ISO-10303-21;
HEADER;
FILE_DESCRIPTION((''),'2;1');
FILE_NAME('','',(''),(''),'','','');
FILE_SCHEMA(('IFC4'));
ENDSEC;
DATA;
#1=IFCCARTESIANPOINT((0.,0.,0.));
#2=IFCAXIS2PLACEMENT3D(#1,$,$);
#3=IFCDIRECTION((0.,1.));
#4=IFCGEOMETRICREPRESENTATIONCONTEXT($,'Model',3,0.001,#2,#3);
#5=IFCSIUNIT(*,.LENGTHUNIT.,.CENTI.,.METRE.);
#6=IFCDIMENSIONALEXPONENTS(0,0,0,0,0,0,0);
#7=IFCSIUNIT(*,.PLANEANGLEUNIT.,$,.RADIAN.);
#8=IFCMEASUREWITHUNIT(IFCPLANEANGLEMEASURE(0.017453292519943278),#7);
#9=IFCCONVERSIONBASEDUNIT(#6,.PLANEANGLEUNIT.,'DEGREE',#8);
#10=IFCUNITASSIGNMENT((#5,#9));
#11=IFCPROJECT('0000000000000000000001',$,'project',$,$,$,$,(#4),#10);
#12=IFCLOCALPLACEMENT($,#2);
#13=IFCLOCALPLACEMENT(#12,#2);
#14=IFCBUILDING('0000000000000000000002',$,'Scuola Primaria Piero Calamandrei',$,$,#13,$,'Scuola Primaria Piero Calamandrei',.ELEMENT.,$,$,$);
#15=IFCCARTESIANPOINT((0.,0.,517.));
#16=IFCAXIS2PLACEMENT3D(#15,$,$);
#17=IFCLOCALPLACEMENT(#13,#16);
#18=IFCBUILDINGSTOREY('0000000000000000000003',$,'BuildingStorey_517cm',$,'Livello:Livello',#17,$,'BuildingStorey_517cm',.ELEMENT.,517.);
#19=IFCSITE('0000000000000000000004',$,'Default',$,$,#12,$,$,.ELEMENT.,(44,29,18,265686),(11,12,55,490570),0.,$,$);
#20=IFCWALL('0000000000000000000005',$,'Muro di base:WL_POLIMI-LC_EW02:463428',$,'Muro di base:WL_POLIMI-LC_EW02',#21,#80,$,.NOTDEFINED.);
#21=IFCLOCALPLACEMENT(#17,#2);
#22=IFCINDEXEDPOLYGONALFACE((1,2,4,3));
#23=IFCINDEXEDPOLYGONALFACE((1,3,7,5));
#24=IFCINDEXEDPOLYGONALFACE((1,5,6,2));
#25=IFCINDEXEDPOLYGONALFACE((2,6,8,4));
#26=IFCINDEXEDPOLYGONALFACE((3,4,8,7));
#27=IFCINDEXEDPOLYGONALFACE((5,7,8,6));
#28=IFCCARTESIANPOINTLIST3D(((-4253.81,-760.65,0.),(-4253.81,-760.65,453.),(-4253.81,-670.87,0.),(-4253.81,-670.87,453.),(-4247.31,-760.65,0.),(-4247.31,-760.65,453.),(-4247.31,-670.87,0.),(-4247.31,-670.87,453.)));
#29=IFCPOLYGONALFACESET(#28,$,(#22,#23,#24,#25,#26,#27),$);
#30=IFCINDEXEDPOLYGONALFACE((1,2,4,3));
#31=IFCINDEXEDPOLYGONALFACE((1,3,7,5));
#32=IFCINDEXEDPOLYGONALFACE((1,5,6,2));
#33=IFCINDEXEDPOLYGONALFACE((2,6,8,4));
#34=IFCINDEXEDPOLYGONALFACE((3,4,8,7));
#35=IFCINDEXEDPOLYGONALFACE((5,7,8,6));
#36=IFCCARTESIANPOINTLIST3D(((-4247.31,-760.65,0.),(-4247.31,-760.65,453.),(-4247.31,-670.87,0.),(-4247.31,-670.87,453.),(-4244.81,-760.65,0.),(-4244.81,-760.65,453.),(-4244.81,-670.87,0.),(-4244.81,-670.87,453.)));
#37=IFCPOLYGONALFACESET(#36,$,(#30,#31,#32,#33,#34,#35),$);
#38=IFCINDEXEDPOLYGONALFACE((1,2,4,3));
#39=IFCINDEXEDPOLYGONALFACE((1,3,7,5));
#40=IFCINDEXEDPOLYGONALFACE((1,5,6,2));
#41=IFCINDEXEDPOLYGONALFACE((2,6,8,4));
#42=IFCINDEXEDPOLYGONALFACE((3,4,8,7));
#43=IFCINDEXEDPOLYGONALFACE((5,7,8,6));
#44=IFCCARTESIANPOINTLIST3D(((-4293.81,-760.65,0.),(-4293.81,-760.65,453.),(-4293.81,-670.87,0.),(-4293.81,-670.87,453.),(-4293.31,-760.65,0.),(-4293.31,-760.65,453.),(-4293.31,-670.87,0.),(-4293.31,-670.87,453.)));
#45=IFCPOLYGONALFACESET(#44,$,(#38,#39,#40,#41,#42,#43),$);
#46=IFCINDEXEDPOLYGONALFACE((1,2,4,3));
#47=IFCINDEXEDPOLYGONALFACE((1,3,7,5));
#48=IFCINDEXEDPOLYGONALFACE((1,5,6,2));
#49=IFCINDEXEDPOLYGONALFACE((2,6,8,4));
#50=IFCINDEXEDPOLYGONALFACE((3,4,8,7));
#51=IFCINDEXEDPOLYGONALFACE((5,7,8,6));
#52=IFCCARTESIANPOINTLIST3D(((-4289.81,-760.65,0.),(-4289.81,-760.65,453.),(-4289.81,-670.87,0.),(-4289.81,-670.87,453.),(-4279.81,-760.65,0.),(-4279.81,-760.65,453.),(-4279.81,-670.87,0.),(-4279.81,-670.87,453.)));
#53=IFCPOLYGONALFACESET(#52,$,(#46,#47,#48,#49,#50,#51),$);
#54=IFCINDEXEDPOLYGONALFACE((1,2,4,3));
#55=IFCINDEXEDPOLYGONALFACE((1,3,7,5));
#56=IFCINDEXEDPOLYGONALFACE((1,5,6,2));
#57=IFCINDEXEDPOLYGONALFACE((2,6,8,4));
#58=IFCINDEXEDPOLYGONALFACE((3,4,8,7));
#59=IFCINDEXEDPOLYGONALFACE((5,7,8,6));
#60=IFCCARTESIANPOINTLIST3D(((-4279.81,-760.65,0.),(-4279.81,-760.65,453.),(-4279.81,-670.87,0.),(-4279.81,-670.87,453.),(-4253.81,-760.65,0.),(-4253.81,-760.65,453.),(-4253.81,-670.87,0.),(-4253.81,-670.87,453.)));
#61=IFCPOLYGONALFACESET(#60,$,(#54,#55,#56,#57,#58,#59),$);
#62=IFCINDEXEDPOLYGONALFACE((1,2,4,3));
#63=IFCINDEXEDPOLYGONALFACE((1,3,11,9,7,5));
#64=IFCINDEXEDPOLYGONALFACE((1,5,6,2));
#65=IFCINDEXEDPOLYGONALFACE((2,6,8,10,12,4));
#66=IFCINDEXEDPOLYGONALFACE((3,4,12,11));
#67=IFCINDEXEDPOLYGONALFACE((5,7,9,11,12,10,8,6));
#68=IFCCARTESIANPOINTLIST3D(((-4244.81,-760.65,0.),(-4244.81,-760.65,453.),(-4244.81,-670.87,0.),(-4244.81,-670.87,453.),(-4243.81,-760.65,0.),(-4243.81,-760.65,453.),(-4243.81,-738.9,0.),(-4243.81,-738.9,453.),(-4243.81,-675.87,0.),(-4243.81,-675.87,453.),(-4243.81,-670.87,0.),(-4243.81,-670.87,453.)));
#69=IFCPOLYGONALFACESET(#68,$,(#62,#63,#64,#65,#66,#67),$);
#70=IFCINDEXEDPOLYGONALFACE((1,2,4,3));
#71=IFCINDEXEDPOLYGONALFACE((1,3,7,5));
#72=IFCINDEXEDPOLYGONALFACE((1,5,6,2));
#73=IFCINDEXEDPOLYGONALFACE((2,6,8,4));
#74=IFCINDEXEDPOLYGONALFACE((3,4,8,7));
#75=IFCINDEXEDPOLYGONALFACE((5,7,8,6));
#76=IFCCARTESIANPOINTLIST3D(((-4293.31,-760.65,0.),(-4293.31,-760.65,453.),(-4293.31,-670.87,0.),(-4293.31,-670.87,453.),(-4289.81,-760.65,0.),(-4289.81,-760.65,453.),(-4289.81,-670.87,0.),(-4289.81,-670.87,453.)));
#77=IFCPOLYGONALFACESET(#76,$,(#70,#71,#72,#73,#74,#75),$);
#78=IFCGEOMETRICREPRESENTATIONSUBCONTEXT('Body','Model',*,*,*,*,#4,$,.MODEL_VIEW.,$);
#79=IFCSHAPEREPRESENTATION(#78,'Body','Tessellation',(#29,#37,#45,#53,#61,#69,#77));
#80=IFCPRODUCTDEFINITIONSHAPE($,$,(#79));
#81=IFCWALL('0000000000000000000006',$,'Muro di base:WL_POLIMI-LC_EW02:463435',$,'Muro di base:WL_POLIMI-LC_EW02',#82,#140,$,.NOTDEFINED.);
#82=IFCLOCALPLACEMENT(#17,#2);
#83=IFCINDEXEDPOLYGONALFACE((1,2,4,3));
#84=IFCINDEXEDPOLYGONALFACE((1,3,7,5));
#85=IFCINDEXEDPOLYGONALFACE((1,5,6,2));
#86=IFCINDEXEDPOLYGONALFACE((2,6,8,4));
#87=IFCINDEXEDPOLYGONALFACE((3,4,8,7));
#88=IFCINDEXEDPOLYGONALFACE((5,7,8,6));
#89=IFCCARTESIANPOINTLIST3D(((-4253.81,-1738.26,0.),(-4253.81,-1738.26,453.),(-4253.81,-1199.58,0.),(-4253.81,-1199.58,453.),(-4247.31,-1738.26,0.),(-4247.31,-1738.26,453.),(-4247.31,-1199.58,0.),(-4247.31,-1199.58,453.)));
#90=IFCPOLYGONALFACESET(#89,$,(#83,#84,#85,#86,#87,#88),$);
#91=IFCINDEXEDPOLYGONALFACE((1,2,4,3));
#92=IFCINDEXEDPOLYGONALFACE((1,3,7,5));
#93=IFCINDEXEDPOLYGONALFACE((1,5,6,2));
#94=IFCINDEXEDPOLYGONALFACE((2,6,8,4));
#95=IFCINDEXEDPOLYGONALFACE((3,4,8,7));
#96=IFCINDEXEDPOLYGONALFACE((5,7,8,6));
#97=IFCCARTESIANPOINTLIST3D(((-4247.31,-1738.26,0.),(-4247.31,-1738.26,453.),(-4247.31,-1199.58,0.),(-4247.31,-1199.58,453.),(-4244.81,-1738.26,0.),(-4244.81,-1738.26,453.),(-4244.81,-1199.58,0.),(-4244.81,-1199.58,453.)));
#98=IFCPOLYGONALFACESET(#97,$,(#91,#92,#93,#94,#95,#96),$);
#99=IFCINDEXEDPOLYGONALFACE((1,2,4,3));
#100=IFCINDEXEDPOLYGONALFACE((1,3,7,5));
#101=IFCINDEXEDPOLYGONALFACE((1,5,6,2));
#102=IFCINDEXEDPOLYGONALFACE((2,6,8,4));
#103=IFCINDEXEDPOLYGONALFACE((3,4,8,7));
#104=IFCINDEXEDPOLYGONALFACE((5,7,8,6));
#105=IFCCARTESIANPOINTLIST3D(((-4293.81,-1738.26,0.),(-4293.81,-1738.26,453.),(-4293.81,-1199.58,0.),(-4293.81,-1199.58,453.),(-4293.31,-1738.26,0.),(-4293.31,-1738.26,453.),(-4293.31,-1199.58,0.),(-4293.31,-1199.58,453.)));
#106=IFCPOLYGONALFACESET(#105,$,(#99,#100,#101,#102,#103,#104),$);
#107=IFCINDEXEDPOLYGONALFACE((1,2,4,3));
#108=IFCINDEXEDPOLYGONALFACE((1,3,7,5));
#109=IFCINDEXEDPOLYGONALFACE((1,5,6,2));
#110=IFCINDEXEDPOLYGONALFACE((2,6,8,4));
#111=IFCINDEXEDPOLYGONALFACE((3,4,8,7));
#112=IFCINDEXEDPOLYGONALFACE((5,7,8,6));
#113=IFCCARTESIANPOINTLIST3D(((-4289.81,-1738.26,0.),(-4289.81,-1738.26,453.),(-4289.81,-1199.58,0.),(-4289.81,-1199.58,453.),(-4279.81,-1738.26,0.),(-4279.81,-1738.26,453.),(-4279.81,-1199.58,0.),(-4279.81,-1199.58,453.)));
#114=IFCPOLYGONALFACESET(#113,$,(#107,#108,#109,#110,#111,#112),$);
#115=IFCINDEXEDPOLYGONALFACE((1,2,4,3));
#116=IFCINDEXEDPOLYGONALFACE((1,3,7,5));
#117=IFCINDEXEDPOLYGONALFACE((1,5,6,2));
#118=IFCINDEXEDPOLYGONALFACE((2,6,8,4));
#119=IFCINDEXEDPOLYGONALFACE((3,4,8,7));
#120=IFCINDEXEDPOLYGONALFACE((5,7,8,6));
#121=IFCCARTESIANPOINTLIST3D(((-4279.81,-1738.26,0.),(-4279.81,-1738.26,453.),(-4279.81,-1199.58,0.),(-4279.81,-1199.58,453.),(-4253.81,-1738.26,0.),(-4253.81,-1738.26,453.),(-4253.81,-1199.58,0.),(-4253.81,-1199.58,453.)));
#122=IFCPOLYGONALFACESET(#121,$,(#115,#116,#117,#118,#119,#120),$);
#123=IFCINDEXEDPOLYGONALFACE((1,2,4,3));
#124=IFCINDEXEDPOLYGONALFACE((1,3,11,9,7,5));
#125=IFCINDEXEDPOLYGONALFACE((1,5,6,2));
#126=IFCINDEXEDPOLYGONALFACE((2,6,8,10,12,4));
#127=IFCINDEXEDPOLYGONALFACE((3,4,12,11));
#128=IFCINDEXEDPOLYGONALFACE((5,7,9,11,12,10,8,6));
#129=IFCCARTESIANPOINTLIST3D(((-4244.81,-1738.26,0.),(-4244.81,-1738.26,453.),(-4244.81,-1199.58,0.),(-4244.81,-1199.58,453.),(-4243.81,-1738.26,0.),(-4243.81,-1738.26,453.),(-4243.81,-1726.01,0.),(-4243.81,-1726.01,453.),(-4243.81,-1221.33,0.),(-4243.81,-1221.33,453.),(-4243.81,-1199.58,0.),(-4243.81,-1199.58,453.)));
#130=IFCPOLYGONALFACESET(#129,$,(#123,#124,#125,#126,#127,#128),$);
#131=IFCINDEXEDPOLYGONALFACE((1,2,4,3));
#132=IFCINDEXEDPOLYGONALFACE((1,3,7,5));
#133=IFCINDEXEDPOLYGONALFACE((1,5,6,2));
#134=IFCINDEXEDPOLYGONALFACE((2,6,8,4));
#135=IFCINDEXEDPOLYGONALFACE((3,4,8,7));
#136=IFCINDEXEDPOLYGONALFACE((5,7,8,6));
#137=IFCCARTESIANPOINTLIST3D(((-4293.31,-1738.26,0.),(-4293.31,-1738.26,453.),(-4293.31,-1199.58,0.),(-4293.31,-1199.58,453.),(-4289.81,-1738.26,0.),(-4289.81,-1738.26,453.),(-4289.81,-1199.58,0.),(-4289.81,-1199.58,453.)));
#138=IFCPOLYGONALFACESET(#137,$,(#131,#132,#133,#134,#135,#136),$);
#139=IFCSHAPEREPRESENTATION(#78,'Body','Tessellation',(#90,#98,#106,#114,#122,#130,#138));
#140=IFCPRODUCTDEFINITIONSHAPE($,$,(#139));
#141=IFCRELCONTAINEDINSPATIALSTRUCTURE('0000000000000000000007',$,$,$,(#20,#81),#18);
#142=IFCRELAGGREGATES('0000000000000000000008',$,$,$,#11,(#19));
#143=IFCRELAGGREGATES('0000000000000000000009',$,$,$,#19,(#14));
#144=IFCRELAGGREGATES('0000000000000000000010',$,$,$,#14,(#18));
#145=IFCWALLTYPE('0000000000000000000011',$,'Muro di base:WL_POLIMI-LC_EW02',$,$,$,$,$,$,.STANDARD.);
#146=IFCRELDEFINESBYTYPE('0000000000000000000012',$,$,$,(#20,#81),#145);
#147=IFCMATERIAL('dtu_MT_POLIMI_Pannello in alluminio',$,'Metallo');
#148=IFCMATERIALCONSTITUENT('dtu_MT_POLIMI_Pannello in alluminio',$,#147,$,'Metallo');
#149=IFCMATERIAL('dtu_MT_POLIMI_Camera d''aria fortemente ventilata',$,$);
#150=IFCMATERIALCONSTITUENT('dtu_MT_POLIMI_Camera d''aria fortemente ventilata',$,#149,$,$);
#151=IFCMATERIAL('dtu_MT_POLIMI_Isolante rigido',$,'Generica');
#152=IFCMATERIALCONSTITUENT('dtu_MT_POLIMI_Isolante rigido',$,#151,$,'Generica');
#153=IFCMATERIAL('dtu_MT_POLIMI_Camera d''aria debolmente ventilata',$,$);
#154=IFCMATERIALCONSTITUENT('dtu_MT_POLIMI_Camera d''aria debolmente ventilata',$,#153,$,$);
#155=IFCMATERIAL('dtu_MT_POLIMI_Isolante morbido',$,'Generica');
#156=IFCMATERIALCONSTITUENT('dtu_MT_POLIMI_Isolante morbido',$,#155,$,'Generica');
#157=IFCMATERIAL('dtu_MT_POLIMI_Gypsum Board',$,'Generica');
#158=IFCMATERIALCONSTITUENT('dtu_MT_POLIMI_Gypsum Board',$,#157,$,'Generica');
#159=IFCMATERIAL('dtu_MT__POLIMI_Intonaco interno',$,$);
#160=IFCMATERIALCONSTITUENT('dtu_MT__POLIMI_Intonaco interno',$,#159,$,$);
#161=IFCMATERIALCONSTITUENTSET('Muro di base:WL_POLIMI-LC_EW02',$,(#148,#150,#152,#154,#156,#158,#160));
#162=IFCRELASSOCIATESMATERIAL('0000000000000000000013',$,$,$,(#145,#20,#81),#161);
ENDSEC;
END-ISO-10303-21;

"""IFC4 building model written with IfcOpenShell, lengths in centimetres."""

from ifc_helpers import new_model, entity, si_unit, converted_unit, direction, frame, origin, place, context, subcontext, project, spatial, indexed_curve, outline, extrude, material, constituent, constituent_set, type_object, element, save


model = new_model("IFC4")

# Units and contexts
model_context = context("Model", 3, precision=0.001, world=origin(), true_north=direction((0.0, 1.0)))
body_context = subcontext(model_context, "Body", "Model", "MODEL_VIEW")
ifc_project = project(units=[si_unit("LENGTHUNIT", "METRE", prefix="CENTI"), converted_unit("PLANEANGLEUNIT", "DEGREE", entity("IfcPlaneAngleMeasure", 0.017453292519943278), si_unit("PLANEANGLEUNIT", "RADIAN"), dimensions=[0, 0, 0, 0, 0, 0, 0])], contexts=[model_context])

# Site, building, storey
site_placement = place(None, origin())
site = spatial("IfcSite", under=ifc_project, at=site_placement, Name="Default", CompositionType="ELEMENT", RefLatitude=(44, 29, 18, 265686), RefLongitude=(11, 12, 55, 490570), RefElevation=0.0)
building_placement = place(site_placement, origin())
building = spatial("IfcBuilding", under=site, at=building_placement, Name="Scuola Primaria Piero Calamandrei", LongName="Scuola Primaria Piero Calamandrei", CompositionType="ELEMENT")
storey_placement = place(building_placement, frame((0.0, 0.0, 517.0)))
storey = spatial("IfcBuildingStorey", under=building, at=storey_placement, Name="BuildingStorey_517cm", ObjectType="Livello:Livello", LongName="BuildingStorey_517cm", CompositionType="ELEMENT", Elevation=517.0)

# Walls
ifc_material_1 = material(Name="dtu_MT_POLIMI_Pannello in alluminio", Category="Metallo")
ifc_constituent_1 = constituent(ifc_material_1, Name="dtu_MT_POLIMI_Pannello in alluminio", Category="Metallo")
ifc_material_2 = material(Name="dtu_MT_POLIMI_Camera d'aria fortemente ventilata")
ifc_constituent_2 = constituent(ifc_material_2, Name="dtu_MT_POLIMI_Camera d'aria fortemente ventilata")
ifc_material_3 = material(Name="dtu_MT_POLIMI_Isolante rigido", Category="Generica")
ifc_constituent_3 = constituent(ifc_material_3, Name="dtu_MT_POLIMI_Isolante rigido", Category="Generica")
ifc_material_4 = material(Name="dtu_MT_POLIMI_Camera d'aria debolmente ventilata")
ifc_constituent_4 = constituent(ifc_material_4, Name="dtu_MT_POLIMI_Camera d'aria debolmente ventilata")
ifc_material_5 = material(Name="dtu_MT_POLIMI_Isolante morbido", Category="Generica")
ifc_constituent_5 = constituent(ifc_material_5, Name="dtu_MT_POLIMI_Isolante morbido", Category="Generica")
ifc_material_6 = material(Name="dtu_MT_POLIMI_Gypsum Board", Category="Generica")
ifc_constituent_6 = constituent(ifc_material_6, Name="dtu_MT_POLIMI_Gypsum Board", Category="Generica")
ifc_material_7 = material(Name="dtu_MT__POLIMI_Intonaco interno")
ifc_constituent_7 = constituent(ifc_material_7, Name="dtu_MT__POLIMI_Intonaco interno")
ifc_constituent_set_1 = constituent_set(constituents=[ifc_constituent_1, ifc_constituent_2, ifc_constituent_3, ifc_constituent_4, ifc_constituent_5, ifc_constituent_6, ifc_constituent_7], Name="Muro di base:WL_POLIMI-LC_EW02")
wall_type_1 = type_object("IfcWallType", Name="Muro di base:WL_POLIMI-LC_EW02", PredefinedType="STANDARD", material=ifc_constituent_set_1)
wall_1_placement = place(storey_placement, frame((-4268.81, -760.65, 0.0), z_axis=(0.0, 0.0, 1.0), x_axis=(0.0, 1.0, 0.0)))
element("IfcWall", 1, at=wall_1_placement, inside=storey, type_object=wall_type_1, material=ifc_constituent_set_1, Name="Muro di base:WL_POLIMI-LC_EW02:463428", ObjectType="Muro di base:WL_POLIMI-LC_EW02", PredefinedType="NOTDEFINED", context=body_context, shape_type="SweptSolid", body=[
    extrude(outline(indexed_curve([(-44.89, -3.25), (44.89, -3.25), (44.89, 3.25), (-44.89, 3.25), (-44.89, -3.25)], self_intersect=False)), frame((44.89, -18.25, 0.0)), (0.0, 0.0, 1.0), 453.0),
    extrude(outline(indexed_curve([(-44.89, -1.25), (44.89, -1.25), (44.89, 1.25), (-44.89, 1.25), (-44.89, -1.25)], self_intersect=False)), frame((44.89, -22.75, 0.0)), (0.0, 0.0, 1.0), 453.0),
    extrude(outline(indexed_curve([(-0.25, -44.89), (0.25, -44.89), (0.25, 44.89), (-0.25, 44.89), (-0.25, -44.89)], self_intersect=False)), frame((44.89, 24.75, 0.0), z_axis=(0.0, 0.0, 1.0), x_axis=(0.0, -1.0, 0.0)), (0.0, 0.0, 1.0), 453.0),
    extrude(outline(indexed_curve([(-44.89, -5.0), (44.89, -5.0), (44.89, 5.0), (-44.89, 5.0), (-44.89, -5.0)], self_intersect=False)), frame((44.89, 16.0, 0.0)), (0.0, 0.0, 1.0), 453.0),
    extrude(outline(indexed_curve([(-44.89, -13.0), (44.89, -13.0), (44.89, 13.0), (-44.89, 13.0), (-44.89, -13.0)], self_intersect=False)), frame((44.89, -2.0, 0.0)), (0.0, 0.0, 1.0), 453.0),
    extrude(outline(indexed_curve([(-25.93, -0.33), (37.1, -0.33), (42.1, -0.33), (42.1, 0.67), (-47.68, 0.67), (-47.68, -0.33), (-25.93, -0.33)], self_intersect=False)), frame((47.68, -24.67, 0.0)), (0.0, 0.0, 1.0), 453.0),
    extrude(outline(indexed_curve([(-44.89, -1.75), (44.89, -1.75), (44.89, 1.75), (-44.89, 1.75), (-44.89, -1.75)], self_intersect=False)), frame((44.89, 22.75, 0.0)), (0.0, 0.0, 1.0), 453.0),
])
wall_2_placement = place(storey_placement, frame((-4268.81, -1738.26, 0.0), z_axis=(0.0, 0.0, 1.0), x_axis=(0.0, 1.0, 0.0)))
element("IfcWall", 2, at=wall_2_placement, inside=storey, type_object=wall_type_1, material=ifc_constituent_set_1, Name="Muro di base:WL_POLIMI-LC_EW02:463435", ObjectType="Muro di base:WL_POLIMI-LC_EW02", PredefinedType="NOTDEFINED", context=body_context, shape_type="SweptSolid", body=[
    extrude(outline(indexed_curve([(-269.34, -3.25), (269.34, -3.25), (269.34, 3.25), (-269.34, 3.25), (-269.34, -3.25)], self_intersect=False)), frame((269.34, -18.25, 0.0)), (0.0, 0.0, 1.0), 453.0),
    extrude(outline(indexed_curve([(-269.34, -1.25), (269.34, -1.25), (269.34, 1.25), (-269.34, 1.25), (-269.34, -1.25)], self_intersect=False)), frame((269.34, -22.75, 0.0)), (0.0, 0.0, 1.0), 453.0),
    extrude(outline(indexed_curve([(-0.25, -269.34), (0.25, -269.34), (0.25, 269.34), (-0.25, 269.34), (-0.25, -269.34)], self_intersect=False)), frame((269.34, 24.75, 0.0), z_axis=(0.0, 0.0, 1.0), x_axis=(0.0, -1.0, 0.0)), (0.0, 0.0, 1.0), 453.0),
    extrude(outline(indexed_curve([(-269.34, -5.0), (269.34, -5.0), (269.34, 5.0), (-269.34, 5.0), (-269.34, -5.0)], self_intersect=False)), frame((269.34, 16.0, 0.0)), (0.0, 0.0, 1.0), 453.0),
    extrude(outline(indexed_curve([(-269.34, -13.0), (269.34, -13.0), (269.34, 13.0), (-269.34, 13.0), (-269.34, -13.0)], self_intersect=False)), frame((269.34, -2.0, 0.0)), (0.0, 0.0, 1.0), 453.0),
    extrude(outline(indexed_curve([(-255.51, -0.33), (249.17, -0.33), (270.92, -0.33), (270.92, 0.67), (-267.76, 0.67), (-267.76, -0.33), (-255.51, -0.33)], self_intersect=False)), frame((267.76, -24.67, 0.0)), (0.0, 0.0, 1.0), 453.0),
    extrude(outline(indexed_curve([(-269.34, -1.75), (269.34, -1.75), (269.34, 1.75), (-269.34, 1.75), (-269.34, -1.75)], self_intersect=False)), frame((269.34, 22.75, 0.0)), (0.0, 0.0, 1.0), 453.0),
])

save(model, "model.ifc")
